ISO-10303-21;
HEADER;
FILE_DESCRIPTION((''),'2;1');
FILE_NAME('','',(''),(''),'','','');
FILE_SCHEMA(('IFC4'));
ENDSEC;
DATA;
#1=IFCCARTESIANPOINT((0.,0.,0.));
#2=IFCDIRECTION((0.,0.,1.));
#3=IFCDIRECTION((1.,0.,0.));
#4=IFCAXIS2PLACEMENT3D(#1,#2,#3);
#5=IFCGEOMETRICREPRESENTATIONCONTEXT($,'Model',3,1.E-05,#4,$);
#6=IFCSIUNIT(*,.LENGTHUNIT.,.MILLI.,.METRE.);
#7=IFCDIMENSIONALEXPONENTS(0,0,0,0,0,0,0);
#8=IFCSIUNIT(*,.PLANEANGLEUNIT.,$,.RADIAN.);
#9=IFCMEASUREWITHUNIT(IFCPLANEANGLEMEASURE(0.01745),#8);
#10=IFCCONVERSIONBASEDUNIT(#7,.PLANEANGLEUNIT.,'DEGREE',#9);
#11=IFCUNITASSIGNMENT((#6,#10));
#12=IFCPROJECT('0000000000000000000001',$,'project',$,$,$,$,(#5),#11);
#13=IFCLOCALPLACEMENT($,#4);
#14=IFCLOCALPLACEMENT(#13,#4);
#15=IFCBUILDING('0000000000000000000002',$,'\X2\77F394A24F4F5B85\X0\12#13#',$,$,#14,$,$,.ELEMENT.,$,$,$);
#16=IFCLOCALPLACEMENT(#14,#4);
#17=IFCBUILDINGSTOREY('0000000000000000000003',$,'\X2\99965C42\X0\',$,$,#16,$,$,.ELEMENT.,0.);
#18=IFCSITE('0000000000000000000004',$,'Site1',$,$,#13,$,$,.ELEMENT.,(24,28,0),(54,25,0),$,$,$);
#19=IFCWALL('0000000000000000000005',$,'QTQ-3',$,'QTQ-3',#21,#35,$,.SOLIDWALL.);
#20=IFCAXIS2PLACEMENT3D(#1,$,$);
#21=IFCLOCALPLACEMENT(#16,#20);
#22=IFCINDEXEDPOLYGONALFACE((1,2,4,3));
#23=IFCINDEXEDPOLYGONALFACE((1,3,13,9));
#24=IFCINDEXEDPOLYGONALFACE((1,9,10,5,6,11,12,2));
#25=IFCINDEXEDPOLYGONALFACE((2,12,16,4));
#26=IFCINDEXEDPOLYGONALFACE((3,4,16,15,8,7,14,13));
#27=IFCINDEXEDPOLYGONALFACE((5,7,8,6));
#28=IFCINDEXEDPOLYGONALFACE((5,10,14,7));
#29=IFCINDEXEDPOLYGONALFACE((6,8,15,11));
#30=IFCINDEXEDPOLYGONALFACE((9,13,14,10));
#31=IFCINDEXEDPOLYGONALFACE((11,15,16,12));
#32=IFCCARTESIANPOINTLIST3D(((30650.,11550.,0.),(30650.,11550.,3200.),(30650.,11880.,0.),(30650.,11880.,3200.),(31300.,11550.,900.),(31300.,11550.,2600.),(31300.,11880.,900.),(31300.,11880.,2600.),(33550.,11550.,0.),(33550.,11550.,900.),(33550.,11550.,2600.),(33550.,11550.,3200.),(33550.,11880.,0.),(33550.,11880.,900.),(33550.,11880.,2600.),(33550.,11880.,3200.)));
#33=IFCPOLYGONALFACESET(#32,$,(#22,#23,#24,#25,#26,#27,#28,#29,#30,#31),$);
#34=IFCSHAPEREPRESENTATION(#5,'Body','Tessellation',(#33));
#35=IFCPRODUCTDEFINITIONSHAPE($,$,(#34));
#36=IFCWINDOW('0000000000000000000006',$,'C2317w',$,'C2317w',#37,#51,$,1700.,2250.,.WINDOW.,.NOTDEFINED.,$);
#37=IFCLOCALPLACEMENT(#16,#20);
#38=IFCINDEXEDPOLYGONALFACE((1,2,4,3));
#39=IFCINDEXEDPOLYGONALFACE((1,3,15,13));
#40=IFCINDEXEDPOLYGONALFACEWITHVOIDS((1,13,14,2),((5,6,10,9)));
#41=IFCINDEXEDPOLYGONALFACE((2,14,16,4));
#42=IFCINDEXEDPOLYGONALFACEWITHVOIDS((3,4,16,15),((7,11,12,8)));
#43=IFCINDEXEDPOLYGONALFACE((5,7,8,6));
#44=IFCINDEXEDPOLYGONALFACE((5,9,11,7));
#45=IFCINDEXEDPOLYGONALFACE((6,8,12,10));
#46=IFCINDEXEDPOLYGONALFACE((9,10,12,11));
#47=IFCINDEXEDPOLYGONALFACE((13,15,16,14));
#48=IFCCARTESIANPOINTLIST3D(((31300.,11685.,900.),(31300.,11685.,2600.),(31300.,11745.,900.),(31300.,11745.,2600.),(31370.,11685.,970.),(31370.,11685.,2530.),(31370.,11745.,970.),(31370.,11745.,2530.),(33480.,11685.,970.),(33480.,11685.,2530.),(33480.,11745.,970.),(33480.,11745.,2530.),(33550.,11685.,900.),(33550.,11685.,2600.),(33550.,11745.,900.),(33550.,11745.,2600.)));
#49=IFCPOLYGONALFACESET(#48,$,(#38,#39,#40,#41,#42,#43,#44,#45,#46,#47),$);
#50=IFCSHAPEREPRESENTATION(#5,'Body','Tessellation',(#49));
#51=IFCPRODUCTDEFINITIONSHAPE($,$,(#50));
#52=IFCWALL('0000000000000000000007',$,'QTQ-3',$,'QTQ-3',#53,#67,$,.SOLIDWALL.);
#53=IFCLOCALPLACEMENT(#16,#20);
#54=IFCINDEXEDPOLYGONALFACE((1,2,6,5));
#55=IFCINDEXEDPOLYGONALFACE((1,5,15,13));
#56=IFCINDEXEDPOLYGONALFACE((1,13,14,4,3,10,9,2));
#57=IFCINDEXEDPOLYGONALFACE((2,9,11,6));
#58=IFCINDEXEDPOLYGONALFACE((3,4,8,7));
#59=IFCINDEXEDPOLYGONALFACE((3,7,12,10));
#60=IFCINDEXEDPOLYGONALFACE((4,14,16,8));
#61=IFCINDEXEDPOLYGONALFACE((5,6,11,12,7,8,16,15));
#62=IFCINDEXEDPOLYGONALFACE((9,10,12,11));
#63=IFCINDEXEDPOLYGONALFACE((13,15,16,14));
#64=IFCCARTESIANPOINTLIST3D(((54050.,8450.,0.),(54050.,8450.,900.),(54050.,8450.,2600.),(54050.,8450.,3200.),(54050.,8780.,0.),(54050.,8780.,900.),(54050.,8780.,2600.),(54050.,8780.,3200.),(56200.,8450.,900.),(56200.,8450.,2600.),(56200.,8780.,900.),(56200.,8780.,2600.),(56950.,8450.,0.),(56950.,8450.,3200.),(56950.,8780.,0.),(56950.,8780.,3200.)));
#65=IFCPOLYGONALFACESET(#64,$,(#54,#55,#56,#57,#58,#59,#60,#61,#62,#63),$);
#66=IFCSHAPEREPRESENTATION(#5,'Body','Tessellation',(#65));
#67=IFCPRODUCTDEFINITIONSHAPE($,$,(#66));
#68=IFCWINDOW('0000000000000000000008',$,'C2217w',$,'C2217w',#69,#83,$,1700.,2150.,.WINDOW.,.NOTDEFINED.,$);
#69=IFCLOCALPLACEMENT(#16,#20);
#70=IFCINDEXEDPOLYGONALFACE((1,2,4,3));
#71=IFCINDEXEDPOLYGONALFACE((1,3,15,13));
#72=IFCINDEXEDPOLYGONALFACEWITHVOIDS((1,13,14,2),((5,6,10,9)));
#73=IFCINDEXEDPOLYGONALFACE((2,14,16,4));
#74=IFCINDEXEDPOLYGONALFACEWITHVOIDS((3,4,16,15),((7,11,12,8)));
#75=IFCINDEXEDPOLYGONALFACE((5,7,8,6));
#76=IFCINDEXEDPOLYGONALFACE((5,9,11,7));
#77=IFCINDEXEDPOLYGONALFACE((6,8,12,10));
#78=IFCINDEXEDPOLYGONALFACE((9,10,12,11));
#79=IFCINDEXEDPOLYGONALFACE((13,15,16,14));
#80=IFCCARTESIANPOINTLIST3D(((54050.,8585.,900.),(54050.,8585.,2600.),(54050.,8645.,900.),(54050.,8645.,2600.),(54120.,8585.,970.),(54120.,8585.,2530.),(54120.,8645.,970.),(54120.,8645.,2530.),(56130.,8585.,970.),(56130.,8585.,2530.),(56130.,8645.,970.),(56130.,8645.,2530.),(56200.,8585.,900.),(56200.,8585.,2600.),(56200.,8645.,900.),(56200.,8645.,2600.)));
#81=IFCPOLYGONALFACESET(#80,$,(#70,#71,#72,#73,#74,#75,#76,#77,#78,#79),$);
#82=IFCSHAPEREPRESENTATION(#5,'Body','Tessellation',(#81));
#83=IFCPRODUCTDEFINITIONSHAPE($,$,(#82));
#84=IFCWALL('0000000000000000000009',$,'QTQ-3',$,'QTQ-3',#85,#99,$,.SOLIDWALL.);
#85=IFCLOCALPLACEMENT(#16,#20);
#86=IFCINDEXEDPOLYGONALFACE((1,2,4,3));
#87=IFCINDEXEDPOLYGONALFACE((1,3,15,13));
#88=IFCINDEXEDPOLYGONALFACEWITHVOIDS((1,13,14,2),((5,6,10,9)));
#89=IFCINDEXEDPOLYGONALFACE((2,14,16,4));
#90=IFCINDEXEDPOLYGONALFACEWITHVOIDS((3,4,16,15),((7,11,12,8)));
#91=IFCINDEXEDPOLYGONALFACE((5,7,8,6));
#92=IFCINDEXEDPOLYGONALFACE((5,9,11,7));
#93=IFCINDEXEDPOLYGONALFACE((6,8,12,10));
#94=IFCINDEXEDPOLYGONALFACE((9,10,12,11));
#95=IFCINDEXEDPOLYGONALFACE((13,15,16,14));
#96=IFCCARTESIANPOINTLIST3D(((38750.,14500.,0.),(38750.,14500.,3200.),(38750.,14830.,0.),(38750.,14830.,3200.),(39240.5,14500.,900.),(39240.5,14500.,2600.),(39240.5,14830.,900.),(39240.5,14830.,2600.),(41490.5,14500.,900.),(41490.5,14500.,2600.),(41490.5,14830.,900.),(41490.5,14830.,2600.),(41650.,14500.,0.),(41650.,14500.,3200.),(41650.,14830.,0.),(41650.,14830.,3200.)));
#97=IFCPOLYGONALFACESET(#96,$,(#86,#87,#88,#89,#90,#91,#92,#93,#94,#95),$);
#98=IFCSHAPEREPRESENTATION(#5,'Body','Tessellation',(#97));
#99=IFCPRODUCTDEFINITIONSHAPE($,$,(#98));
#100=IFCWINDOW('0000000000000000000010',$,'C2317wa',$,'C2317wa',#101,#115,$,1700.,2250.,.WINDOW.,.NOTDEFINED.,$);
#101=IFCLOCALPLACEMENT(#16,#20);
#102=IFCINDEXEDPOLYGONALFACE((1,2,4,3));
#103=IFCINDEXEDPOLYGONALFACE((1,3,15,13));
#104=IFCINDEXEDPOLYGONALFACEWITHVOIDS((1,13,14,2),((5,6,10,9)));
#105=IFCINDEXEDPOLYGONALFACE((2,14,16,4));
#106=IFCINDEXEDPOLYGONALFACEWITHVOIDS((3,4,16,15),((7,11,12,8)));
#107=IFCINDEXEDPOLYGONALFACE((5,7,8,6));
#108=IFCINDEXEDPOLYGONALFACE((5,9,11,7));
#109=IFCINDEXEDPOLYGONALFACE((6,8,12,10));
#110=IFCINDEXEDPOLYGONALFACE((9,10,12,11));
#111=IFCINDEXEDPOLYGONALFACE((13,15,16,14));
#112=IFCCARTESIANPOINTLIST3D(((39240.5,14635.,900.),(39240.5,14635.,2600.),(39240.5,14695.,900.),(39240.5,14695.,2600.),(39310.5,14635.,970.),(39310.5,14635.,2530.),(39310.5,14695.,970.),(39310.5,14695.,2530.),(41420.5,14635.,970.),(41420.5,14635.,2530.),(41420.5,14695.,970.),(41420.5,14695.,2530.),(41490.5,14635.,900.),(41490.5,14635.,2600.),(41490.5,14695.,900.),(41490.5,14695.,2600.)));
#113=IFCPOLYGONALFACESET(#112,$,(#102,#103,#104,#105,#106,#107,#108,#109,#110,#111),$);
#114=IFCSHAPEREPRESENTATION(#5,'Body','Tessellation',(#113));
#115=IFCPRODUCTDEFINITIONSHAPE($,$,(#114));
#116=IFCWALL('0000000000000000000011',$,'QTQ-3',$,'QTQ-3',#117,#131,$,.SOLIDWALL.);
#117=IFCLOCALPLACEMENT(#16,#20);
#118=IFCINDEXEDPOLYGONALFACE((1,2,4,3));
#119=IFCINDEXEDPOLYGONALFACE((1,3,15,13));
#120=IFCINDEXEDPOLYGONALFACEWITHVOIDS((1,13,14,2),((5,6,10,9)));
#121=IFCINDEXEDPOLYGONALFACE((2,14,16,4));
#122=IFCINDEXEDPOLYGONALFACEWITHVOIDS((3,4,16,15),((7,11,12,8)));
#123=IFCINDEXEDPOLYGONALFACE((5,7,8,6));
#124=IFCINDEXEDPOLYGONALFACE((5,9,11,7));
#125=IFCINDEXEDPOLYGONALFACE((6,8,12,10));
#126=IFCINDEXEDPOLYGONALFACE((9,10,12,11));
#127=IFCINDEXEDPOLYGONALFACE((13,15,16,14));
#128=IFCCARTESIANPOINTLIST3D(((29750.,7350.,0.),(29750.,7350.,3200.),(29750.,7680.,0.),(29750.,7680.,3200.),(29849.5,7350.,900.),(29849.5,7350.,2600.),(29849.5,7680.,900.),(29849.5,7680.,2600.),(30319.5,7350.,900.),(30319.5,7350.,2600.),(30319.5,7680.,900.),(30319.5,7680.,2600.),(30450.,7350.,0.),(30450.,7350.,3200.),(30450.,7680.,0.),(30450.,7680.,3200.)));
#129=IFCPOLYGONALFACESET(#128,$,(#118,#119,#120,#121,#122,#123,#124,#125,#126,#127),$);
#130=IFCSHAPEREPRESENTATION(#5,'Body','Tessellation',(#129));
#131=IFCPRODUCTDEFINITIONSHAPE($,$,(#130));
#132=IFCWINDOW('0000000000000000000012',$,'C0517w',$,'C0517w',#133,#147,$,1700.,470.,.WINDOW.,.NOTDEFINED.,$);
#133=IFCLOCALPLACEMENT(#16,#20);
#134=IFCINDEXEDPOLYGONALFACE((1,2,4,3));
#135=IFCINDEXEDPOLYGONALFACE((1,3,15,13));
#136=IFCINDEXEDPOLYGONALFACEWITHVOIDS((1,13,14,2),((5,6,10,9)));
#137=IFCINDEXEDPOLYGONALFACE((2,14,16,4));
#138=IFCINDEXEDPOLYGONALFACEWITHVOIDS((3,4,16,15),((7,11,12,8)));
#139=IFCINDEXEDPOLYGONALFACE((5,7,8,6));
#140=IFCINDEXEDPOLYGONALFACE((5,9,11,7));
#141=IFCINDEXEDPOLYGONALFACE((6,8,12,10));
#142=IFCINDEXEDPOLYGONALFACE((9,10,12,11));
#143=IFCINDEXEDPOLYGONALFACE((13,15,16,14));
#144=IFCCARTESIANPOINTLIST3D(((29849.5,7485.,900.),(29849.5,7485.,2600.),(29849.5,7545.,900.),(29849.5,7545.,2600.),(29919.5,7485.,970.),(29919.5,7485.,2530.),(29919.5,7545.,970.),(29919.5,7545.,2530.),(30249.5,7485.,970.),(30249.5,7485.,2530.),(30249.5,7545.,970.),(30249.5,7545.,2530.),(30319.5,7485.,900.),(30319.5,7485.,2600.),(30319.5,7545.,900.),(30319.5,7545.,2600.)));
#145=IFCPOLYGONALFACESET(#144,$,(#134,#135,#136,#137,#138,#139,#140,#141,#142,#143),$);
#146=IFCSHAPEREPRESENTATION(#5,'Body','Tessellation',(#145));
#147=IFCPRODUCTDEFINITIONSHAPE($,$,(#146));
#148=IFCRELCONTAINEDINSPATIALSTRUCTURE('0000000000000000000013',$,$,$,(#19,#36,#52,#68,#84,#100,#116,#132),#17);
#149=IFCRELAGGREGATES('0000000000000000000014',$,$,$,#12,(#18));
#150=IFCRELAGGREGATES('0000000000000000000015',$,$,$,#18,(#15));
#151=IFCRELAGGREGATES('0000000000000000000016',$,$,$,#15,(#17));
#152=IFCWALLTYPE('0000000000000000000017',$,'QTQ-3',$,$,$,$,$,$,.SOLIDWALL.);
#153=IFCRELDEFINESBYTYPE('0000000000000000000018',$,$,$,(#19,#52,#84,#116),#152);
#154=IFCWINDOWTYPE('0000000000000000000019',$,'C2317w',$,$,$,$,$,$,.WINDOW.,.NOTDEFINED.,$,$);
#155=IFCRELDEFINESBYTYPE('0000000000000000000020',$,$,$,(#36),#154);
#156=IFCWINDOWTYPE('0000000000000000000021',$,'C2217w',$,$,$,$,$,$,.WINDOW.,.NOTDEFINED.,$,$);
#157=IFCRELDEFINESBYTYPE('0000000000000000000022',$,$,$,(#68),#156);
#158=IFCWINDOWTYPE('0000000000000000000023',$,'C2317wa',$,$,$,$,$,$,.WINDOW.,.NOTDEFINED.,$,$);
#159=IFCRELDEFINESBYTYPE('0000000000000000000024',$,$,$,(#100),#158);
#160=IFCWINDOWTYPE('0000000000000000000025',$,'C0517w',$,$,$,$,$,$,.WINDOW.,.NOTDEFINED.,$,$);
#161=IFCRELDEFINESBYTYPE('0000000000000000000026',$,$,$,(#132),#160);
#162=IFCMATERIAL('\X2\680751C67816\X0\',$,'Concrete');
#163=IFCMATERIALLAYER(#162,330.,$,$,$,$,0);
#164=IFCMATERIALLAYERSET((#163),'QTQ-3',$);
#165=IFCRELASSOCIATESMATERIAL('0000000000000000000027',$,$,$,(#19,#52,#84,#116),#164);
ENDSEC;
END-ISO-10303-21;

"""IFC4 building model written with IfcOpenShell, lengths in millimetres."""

from ifc_helpers import new_model, entity, si_unit, converted_unit, frame, origin_with_axes, place, context, project, spatial, polyline, outline, extrude, material, layer, layer_set, type_object, element, fill, save


model = new_model("IFC4")

# Units and contexts
model_context = context("Model", 3, precision=1e-05, world=origin_with_axes())
ifc_project = project(units=[si_unit("LENGTHUNIT", "METRE", prefix="MILLI"), converted_unit("PLANEANGLEUNIT", "DEGREE", entity("IfcPlaneAngleMeasure", 0.01745), si_unit("PLANEANGLEUNIT", "RADIAN"), dimensions=[0, 0, 0, 0, 0, 0, 0])], contexts=[model_context])

# Site, building, storey
site_placement = place(None, origin_with_axes())
site = spatial("IfcSite", under=ifc_project, at=site_placement, Name="Site1", CompositionType="ELEMENT", RefLatitude=(24, 28, 0), RefLongitude=(54, 25, 0))
building_placement = place(site_placement, origin_with_axes())
building = spatial("IfcBuilding", under=site, at=building_placement, Name="石钢住宅12#13#", CompositionType="ELEMENT")
storey_placement = place(building_placement, origin_with_axes())
storey = spatial("IfcBuildingStorey", under=building, at=storey_placement, Name="首层", CompositionType="ELEMENT", Elevation=0.0)

# Walls, openings, windows
ifc_material = material(Name="标准砖", Category="Concrete")
ifc_layer = layer(ifc_material, 330.0, Priority=0)
ifc_layer_set = layer_set([ifc_layer], Name="QTQ-3")
wall_type = type_object("IfcWallType", Name="QTQ-3", PredefinedType="SOLIDWALL")
wall_1_placement = place(storey_placement, origin_with_axes())
wall_1 = element("IfcWall", 1, at=wall_1_placement, inside=storey, type_object=wall_type, material=ifc_layer_set, Name="QTQ-3", ObjectType="QTQ-3", PredefinedType="SOLIDWALL", context=model_context, shape_type="SweptSolid", body=[
    extrude(outline(polyline([(0.0, 0.0), (3200.0, 0.0), (3200.0, 2900.0), (0.0, 2900.0), (0.0, 0.0)])), frame((33550.0, 11550.0, 3200.0), z_axis=(0.0, 1.0, 0.0), x_axis=(0.0, 0.0, -1.0)), (0.0, 0.0, 1.0), 330.0),
])
opening_1_placement = place(storey_placement, origin_with_axes())
opening_1 = element("IfcOpeningElement", 2, at=opening_1_placement, cuts=wall_1, PredefinedType="OPENING", context=model_context, shape_type="SweptSolid", body=[
    extrude(outline(polyline([(0.0, 0.0), (2250.0, 0.0), (2250.0, 1700.0), (0.0, 1700.0), (0.0, 0.0)])), frame((33550.0, 10550.0, 900.0), z_axis=(0.0, 1.0, 0.0), x_axis=(-1.0, 0.0, 0.0)), (0.0, 0.0, 1.0), 2330.0),
])
window_type_1 = type_object("IfcWindowType", Name="C2317w", PartitioningType="NOTDEFINED", PredefinedType="WINDOW")
window_1_placement = place(storey_placement, origin_with_axes())
window_1 = element("IfcWindow", 3, at=window_1_placement, inside=storey, type_object=window_type_1, Name="C2317w", ObjectType="C2317w", OverallHeight=1700.0, OverallWidth=2250.0, PartitioningType="NOTDEFINED", PredefinedType="WINDOW", context=model_context, shape_type="SweptSolid", body=[
    extrude(outline(polyline([(-1125.0, -850.0), (1125.0, -850.0), (1125.0, 850.0), (-1125.0, 850.0), (-1125.0, -850.0)]), holes=[polyline([(-1055.0, -780.0), (-1055.0, 780.0), (1055.0, 780.0), (1055.0, -780.0), (-1055.0, -780.0)])]), frame((32425.0, 11685.0, 1750.0), z_axis=(0.0, 1.0, 0.0), x_axis=(-1.0, 0.0, 0.0)), (0.0, 0.0, 1.0), 60.0),
])
fill(opening_1, window_1)
wall_2_placement = place(storey_placement, origin_with_axes())
wall_2 = element("IfcWall", 4, at=wall_2_placement, inside=storey, type_object=wall_type, material=ifc_layer_set, Name="QTQ-3", ObjectType="QTQ-3", PredefinedType="SOLIDWALL", context=model_context, shape_type="SweptSolid", body=[
    extrude(outline(polyline([(0.0, 0.0), (3200.0, 0.0), (3200.0, 2900.0), (0.0, 2900.0), (0.0, 0.0)])), frame((56950.0, 8450.0, 3200.0), z_axis=(0.0, 1.0, 0.0), x_axis=(0.0, 0.0, -1.0)), (0.0, 0.0, 1.0), 330.0),
])
opening_2_placement = place(storey_placement, origin_with_axes())
opening_2 = element("IfcOpeningElement", 5, at=opening_2_placement, cuts=wall_2, PredefinedType="OPENING", context=model_context, shape_type="SweptSolid", body=[
    extrude(outline(polyline([(0.0, 0.0), (2150.0, 0.0), (2150.0, 1700.0), (0.0, 1700.0), (0.0, 0.0)])), frame((56200.0, 7450.0, 900.0), z_axis=(0.0, 1.0, 0.0), x_axis=(-1.0, 0.0, 0.0)), (0.0, 0.0, 1.0), 2330.0),
])
window_type_2 = type_object("IfcWindowType", Name="C2217w", PartitioningType="NOTDEFINED", PredefinedType="WINDOW")
window_2_placement = place(storey_placement, origin_with_axes())
window_2 = element("IfcWindow", 6, at=window_2_placement, inside=storey, type_object=window_type_2, Name="C2217w", ObjectType="C2217w", OverallHeight=1700.0, OverallWidth=2150.0, PartitioningType="NOTDEFINED", PredefinedType="WINDOW", context=model_context, shape_type="SweptSolid", body=[
    extrude(outline(polyline([(-1075.0, -850.0), (1075.0, -850.0), (1075.0, 850.0), (-1075.0, 850.0), (-1075.0, -850.0)]), holes=[polyline([(-1005.0, -780.0), (-1005.0, 780.0), (1005.0, 780.0), (1005.0, -780.0), (-1005.0, -780.0)])]), frame((55125.0, 8585.0, 1750.0), z_axis=(0.0, 1.0, 0.0), x_axis=(-1.0, 0.0, 0.0)), (0.0, 0.0, 1.0), 60.0),
])
fill(opening_2, window_2)
wall_3_placement = place(storey_placement, origin_with_axes())
wall_3 = element("IfcWall", 7, at=wall_3_placement, inside=storey, type_object=wall_type, material=ifc_layer_set, Name="QTQ-3", ObjectType="QTQ-3", PredefinedType="SOLIDWALL", context=model_context, shape_type="SweptSolid", body=[
    extrude(outline(polyline([(0.0, 0.0), (3200.0, 0.0), (3200.0, 2900.0), (0.0, 2900.0), (0.0, 0.0)])), frame((41650.0, 14500.0, 3200.0), z_axis=(0.0, 1.0, 0.0), x_axis=(0.0, 0.0, -1.0)), (0.0, 0.0, 1.0), 330.0),
])
opening_3_placement = place(storey_placement, origin_with_axes())
opening_3 = element("IfcOpeningElement", 8, at=opening_3_placement, cuts=wall_3, PredefinedType="OPENING", context=model_context, shape_type="SweptSolid", body=[
    extrude(outline(polyline([(0.0, 0.0), (2250.0, 0.0), (2250.0, 1700.0), (0.0, 1700.0), (0.0, 0.0)])), frame((41490.5, 13500.0, 900.0), z_axis=(0.0, 1.0, 0.0), x_axis=(-1.0, 0.0, 0.0)), (0.0, 0.0, 1.0), 2330.0),
])
window_type_3 = type_object("IfcWindowType", Name="C2317wa", PartitioningType="NOTDEFINED", PredefinedType="WINDOW")
window_3_placement = place(storey_placement, origin_with_axes())
window_3 = element("IfcWindow", 9, at=window_3_placement, inside=storey, type_object=window_type_3, Name="C2317wa", ObjectType="C2317wa", OverallHeight=1700.0, OverallWidth=2250.0, PartitioningType="NOTDEFINED", PredefinedType="WINDOW", context=model_context, shape_type="SweptSolid", body=[
    extrude(outline(polyline([(-1125.0, -850.0), (1125.0, -850.0), (1125.0, 850.0), (-1125.0, 850.0), (-1125.0, -850.0)]), holes=[polyline([(-1055.0, -780.0), (-1055.0, 780.0), (1055.0, 780.0), (1055.0, -780.0), (-1055.0, -780.0)])]), frame((40365.5, 14635.0, 1750.0), z_axis=(0.0, 1.0, 0.0), x_axis=(-1.0, 0.0, 0.0)), (0.0, 0.0, 1.0), 60.0),
])
fill(opening_3, window_3)
wall_4_placement = place(storey_placement, origin_with_axes())
wall_4 = element("IfcWall", 10, at=wall_4_placement, inside=storey, type_object=wall_type, material=ifc_layer_set, Name="QTQ-3", ObjectType="QTQ-3", PredefinedType="SOLIDWALL", context=model_context, shape_type="SweptSolid", body=[
    extrude(outline(polyline([(0.0, 0.0), (3200.0, 0.0), (3200.0, 700.0), (0.0, 700.0), (0.0, 0.0)])), frame((30450.0, 7350.0, 3200.0), z_axis=(0.0, 1.0, 0.0), x_axis=(0.0, 0.0, -1.0)), (0.0, 0.0, 1.0), 330.0),
])
opening_4_placement = place(storey_placement, origin_with_axes())
opening_4 = element("IfcOpeningElement", 11, at=opening_4_placement, cuts=wall_4, PredefinedType="OPENING", context=model_context, shape_type="SweptSolid", body=[
    extrude(outline(polyline([(0.0, 0.0), (470.0, 0.0), (470.0, 1700.0), (0.0, 1700.0), (0.0, 0.0)])), frame((30319.5, 6350.0, 900.0), z_axis=(0.0, 1.0, 0.0), x_axis=(-1.0, 0.0, 0.0)), (0.0, 0.0, 1.0), 2330.0),
])
window_type_4 = type_object("IfcWindowType", Name="C0517w", PartitioningType="NOTDEFINED", PredefinedType="WINDOW")
window_4_placement = place(storey_placement, origin_with_axes())
window_4 = element("IfcWindow", 12, at=window_4_placement, inside=storey, type_object=window_type_4, Name="C0517w", ObjectType="C0517w", OverallHeight=1700.0, OverallWidth=470.0, PartitioningType="NOTDEFINED", PredefinedType="WINDOW", context=model_context, shape_type="SweptSolid", body=[
    extrude(outline(polyline([(-235.0, -850.0), (235.0, -850.0), (235.0, 850.0), (-235.0, 850.0), (-235.0, -850.0)]), holes=[polyline([(-165.0, -780.0), (-165.0, 780.0), (165.0, 780.0), (165.0, -780.0), (-165.0, -780.0)])]), frame((30084.5, 7485.0, 1750.0), z_axis=(0.0, 1.0, 0.0), x_axis=(-1.0, 0.0, 0.0)), (0.0, 0.0, 1.0), 60.0),
])
fill(opening_4, window_4)

save(model, "model.ifc")
